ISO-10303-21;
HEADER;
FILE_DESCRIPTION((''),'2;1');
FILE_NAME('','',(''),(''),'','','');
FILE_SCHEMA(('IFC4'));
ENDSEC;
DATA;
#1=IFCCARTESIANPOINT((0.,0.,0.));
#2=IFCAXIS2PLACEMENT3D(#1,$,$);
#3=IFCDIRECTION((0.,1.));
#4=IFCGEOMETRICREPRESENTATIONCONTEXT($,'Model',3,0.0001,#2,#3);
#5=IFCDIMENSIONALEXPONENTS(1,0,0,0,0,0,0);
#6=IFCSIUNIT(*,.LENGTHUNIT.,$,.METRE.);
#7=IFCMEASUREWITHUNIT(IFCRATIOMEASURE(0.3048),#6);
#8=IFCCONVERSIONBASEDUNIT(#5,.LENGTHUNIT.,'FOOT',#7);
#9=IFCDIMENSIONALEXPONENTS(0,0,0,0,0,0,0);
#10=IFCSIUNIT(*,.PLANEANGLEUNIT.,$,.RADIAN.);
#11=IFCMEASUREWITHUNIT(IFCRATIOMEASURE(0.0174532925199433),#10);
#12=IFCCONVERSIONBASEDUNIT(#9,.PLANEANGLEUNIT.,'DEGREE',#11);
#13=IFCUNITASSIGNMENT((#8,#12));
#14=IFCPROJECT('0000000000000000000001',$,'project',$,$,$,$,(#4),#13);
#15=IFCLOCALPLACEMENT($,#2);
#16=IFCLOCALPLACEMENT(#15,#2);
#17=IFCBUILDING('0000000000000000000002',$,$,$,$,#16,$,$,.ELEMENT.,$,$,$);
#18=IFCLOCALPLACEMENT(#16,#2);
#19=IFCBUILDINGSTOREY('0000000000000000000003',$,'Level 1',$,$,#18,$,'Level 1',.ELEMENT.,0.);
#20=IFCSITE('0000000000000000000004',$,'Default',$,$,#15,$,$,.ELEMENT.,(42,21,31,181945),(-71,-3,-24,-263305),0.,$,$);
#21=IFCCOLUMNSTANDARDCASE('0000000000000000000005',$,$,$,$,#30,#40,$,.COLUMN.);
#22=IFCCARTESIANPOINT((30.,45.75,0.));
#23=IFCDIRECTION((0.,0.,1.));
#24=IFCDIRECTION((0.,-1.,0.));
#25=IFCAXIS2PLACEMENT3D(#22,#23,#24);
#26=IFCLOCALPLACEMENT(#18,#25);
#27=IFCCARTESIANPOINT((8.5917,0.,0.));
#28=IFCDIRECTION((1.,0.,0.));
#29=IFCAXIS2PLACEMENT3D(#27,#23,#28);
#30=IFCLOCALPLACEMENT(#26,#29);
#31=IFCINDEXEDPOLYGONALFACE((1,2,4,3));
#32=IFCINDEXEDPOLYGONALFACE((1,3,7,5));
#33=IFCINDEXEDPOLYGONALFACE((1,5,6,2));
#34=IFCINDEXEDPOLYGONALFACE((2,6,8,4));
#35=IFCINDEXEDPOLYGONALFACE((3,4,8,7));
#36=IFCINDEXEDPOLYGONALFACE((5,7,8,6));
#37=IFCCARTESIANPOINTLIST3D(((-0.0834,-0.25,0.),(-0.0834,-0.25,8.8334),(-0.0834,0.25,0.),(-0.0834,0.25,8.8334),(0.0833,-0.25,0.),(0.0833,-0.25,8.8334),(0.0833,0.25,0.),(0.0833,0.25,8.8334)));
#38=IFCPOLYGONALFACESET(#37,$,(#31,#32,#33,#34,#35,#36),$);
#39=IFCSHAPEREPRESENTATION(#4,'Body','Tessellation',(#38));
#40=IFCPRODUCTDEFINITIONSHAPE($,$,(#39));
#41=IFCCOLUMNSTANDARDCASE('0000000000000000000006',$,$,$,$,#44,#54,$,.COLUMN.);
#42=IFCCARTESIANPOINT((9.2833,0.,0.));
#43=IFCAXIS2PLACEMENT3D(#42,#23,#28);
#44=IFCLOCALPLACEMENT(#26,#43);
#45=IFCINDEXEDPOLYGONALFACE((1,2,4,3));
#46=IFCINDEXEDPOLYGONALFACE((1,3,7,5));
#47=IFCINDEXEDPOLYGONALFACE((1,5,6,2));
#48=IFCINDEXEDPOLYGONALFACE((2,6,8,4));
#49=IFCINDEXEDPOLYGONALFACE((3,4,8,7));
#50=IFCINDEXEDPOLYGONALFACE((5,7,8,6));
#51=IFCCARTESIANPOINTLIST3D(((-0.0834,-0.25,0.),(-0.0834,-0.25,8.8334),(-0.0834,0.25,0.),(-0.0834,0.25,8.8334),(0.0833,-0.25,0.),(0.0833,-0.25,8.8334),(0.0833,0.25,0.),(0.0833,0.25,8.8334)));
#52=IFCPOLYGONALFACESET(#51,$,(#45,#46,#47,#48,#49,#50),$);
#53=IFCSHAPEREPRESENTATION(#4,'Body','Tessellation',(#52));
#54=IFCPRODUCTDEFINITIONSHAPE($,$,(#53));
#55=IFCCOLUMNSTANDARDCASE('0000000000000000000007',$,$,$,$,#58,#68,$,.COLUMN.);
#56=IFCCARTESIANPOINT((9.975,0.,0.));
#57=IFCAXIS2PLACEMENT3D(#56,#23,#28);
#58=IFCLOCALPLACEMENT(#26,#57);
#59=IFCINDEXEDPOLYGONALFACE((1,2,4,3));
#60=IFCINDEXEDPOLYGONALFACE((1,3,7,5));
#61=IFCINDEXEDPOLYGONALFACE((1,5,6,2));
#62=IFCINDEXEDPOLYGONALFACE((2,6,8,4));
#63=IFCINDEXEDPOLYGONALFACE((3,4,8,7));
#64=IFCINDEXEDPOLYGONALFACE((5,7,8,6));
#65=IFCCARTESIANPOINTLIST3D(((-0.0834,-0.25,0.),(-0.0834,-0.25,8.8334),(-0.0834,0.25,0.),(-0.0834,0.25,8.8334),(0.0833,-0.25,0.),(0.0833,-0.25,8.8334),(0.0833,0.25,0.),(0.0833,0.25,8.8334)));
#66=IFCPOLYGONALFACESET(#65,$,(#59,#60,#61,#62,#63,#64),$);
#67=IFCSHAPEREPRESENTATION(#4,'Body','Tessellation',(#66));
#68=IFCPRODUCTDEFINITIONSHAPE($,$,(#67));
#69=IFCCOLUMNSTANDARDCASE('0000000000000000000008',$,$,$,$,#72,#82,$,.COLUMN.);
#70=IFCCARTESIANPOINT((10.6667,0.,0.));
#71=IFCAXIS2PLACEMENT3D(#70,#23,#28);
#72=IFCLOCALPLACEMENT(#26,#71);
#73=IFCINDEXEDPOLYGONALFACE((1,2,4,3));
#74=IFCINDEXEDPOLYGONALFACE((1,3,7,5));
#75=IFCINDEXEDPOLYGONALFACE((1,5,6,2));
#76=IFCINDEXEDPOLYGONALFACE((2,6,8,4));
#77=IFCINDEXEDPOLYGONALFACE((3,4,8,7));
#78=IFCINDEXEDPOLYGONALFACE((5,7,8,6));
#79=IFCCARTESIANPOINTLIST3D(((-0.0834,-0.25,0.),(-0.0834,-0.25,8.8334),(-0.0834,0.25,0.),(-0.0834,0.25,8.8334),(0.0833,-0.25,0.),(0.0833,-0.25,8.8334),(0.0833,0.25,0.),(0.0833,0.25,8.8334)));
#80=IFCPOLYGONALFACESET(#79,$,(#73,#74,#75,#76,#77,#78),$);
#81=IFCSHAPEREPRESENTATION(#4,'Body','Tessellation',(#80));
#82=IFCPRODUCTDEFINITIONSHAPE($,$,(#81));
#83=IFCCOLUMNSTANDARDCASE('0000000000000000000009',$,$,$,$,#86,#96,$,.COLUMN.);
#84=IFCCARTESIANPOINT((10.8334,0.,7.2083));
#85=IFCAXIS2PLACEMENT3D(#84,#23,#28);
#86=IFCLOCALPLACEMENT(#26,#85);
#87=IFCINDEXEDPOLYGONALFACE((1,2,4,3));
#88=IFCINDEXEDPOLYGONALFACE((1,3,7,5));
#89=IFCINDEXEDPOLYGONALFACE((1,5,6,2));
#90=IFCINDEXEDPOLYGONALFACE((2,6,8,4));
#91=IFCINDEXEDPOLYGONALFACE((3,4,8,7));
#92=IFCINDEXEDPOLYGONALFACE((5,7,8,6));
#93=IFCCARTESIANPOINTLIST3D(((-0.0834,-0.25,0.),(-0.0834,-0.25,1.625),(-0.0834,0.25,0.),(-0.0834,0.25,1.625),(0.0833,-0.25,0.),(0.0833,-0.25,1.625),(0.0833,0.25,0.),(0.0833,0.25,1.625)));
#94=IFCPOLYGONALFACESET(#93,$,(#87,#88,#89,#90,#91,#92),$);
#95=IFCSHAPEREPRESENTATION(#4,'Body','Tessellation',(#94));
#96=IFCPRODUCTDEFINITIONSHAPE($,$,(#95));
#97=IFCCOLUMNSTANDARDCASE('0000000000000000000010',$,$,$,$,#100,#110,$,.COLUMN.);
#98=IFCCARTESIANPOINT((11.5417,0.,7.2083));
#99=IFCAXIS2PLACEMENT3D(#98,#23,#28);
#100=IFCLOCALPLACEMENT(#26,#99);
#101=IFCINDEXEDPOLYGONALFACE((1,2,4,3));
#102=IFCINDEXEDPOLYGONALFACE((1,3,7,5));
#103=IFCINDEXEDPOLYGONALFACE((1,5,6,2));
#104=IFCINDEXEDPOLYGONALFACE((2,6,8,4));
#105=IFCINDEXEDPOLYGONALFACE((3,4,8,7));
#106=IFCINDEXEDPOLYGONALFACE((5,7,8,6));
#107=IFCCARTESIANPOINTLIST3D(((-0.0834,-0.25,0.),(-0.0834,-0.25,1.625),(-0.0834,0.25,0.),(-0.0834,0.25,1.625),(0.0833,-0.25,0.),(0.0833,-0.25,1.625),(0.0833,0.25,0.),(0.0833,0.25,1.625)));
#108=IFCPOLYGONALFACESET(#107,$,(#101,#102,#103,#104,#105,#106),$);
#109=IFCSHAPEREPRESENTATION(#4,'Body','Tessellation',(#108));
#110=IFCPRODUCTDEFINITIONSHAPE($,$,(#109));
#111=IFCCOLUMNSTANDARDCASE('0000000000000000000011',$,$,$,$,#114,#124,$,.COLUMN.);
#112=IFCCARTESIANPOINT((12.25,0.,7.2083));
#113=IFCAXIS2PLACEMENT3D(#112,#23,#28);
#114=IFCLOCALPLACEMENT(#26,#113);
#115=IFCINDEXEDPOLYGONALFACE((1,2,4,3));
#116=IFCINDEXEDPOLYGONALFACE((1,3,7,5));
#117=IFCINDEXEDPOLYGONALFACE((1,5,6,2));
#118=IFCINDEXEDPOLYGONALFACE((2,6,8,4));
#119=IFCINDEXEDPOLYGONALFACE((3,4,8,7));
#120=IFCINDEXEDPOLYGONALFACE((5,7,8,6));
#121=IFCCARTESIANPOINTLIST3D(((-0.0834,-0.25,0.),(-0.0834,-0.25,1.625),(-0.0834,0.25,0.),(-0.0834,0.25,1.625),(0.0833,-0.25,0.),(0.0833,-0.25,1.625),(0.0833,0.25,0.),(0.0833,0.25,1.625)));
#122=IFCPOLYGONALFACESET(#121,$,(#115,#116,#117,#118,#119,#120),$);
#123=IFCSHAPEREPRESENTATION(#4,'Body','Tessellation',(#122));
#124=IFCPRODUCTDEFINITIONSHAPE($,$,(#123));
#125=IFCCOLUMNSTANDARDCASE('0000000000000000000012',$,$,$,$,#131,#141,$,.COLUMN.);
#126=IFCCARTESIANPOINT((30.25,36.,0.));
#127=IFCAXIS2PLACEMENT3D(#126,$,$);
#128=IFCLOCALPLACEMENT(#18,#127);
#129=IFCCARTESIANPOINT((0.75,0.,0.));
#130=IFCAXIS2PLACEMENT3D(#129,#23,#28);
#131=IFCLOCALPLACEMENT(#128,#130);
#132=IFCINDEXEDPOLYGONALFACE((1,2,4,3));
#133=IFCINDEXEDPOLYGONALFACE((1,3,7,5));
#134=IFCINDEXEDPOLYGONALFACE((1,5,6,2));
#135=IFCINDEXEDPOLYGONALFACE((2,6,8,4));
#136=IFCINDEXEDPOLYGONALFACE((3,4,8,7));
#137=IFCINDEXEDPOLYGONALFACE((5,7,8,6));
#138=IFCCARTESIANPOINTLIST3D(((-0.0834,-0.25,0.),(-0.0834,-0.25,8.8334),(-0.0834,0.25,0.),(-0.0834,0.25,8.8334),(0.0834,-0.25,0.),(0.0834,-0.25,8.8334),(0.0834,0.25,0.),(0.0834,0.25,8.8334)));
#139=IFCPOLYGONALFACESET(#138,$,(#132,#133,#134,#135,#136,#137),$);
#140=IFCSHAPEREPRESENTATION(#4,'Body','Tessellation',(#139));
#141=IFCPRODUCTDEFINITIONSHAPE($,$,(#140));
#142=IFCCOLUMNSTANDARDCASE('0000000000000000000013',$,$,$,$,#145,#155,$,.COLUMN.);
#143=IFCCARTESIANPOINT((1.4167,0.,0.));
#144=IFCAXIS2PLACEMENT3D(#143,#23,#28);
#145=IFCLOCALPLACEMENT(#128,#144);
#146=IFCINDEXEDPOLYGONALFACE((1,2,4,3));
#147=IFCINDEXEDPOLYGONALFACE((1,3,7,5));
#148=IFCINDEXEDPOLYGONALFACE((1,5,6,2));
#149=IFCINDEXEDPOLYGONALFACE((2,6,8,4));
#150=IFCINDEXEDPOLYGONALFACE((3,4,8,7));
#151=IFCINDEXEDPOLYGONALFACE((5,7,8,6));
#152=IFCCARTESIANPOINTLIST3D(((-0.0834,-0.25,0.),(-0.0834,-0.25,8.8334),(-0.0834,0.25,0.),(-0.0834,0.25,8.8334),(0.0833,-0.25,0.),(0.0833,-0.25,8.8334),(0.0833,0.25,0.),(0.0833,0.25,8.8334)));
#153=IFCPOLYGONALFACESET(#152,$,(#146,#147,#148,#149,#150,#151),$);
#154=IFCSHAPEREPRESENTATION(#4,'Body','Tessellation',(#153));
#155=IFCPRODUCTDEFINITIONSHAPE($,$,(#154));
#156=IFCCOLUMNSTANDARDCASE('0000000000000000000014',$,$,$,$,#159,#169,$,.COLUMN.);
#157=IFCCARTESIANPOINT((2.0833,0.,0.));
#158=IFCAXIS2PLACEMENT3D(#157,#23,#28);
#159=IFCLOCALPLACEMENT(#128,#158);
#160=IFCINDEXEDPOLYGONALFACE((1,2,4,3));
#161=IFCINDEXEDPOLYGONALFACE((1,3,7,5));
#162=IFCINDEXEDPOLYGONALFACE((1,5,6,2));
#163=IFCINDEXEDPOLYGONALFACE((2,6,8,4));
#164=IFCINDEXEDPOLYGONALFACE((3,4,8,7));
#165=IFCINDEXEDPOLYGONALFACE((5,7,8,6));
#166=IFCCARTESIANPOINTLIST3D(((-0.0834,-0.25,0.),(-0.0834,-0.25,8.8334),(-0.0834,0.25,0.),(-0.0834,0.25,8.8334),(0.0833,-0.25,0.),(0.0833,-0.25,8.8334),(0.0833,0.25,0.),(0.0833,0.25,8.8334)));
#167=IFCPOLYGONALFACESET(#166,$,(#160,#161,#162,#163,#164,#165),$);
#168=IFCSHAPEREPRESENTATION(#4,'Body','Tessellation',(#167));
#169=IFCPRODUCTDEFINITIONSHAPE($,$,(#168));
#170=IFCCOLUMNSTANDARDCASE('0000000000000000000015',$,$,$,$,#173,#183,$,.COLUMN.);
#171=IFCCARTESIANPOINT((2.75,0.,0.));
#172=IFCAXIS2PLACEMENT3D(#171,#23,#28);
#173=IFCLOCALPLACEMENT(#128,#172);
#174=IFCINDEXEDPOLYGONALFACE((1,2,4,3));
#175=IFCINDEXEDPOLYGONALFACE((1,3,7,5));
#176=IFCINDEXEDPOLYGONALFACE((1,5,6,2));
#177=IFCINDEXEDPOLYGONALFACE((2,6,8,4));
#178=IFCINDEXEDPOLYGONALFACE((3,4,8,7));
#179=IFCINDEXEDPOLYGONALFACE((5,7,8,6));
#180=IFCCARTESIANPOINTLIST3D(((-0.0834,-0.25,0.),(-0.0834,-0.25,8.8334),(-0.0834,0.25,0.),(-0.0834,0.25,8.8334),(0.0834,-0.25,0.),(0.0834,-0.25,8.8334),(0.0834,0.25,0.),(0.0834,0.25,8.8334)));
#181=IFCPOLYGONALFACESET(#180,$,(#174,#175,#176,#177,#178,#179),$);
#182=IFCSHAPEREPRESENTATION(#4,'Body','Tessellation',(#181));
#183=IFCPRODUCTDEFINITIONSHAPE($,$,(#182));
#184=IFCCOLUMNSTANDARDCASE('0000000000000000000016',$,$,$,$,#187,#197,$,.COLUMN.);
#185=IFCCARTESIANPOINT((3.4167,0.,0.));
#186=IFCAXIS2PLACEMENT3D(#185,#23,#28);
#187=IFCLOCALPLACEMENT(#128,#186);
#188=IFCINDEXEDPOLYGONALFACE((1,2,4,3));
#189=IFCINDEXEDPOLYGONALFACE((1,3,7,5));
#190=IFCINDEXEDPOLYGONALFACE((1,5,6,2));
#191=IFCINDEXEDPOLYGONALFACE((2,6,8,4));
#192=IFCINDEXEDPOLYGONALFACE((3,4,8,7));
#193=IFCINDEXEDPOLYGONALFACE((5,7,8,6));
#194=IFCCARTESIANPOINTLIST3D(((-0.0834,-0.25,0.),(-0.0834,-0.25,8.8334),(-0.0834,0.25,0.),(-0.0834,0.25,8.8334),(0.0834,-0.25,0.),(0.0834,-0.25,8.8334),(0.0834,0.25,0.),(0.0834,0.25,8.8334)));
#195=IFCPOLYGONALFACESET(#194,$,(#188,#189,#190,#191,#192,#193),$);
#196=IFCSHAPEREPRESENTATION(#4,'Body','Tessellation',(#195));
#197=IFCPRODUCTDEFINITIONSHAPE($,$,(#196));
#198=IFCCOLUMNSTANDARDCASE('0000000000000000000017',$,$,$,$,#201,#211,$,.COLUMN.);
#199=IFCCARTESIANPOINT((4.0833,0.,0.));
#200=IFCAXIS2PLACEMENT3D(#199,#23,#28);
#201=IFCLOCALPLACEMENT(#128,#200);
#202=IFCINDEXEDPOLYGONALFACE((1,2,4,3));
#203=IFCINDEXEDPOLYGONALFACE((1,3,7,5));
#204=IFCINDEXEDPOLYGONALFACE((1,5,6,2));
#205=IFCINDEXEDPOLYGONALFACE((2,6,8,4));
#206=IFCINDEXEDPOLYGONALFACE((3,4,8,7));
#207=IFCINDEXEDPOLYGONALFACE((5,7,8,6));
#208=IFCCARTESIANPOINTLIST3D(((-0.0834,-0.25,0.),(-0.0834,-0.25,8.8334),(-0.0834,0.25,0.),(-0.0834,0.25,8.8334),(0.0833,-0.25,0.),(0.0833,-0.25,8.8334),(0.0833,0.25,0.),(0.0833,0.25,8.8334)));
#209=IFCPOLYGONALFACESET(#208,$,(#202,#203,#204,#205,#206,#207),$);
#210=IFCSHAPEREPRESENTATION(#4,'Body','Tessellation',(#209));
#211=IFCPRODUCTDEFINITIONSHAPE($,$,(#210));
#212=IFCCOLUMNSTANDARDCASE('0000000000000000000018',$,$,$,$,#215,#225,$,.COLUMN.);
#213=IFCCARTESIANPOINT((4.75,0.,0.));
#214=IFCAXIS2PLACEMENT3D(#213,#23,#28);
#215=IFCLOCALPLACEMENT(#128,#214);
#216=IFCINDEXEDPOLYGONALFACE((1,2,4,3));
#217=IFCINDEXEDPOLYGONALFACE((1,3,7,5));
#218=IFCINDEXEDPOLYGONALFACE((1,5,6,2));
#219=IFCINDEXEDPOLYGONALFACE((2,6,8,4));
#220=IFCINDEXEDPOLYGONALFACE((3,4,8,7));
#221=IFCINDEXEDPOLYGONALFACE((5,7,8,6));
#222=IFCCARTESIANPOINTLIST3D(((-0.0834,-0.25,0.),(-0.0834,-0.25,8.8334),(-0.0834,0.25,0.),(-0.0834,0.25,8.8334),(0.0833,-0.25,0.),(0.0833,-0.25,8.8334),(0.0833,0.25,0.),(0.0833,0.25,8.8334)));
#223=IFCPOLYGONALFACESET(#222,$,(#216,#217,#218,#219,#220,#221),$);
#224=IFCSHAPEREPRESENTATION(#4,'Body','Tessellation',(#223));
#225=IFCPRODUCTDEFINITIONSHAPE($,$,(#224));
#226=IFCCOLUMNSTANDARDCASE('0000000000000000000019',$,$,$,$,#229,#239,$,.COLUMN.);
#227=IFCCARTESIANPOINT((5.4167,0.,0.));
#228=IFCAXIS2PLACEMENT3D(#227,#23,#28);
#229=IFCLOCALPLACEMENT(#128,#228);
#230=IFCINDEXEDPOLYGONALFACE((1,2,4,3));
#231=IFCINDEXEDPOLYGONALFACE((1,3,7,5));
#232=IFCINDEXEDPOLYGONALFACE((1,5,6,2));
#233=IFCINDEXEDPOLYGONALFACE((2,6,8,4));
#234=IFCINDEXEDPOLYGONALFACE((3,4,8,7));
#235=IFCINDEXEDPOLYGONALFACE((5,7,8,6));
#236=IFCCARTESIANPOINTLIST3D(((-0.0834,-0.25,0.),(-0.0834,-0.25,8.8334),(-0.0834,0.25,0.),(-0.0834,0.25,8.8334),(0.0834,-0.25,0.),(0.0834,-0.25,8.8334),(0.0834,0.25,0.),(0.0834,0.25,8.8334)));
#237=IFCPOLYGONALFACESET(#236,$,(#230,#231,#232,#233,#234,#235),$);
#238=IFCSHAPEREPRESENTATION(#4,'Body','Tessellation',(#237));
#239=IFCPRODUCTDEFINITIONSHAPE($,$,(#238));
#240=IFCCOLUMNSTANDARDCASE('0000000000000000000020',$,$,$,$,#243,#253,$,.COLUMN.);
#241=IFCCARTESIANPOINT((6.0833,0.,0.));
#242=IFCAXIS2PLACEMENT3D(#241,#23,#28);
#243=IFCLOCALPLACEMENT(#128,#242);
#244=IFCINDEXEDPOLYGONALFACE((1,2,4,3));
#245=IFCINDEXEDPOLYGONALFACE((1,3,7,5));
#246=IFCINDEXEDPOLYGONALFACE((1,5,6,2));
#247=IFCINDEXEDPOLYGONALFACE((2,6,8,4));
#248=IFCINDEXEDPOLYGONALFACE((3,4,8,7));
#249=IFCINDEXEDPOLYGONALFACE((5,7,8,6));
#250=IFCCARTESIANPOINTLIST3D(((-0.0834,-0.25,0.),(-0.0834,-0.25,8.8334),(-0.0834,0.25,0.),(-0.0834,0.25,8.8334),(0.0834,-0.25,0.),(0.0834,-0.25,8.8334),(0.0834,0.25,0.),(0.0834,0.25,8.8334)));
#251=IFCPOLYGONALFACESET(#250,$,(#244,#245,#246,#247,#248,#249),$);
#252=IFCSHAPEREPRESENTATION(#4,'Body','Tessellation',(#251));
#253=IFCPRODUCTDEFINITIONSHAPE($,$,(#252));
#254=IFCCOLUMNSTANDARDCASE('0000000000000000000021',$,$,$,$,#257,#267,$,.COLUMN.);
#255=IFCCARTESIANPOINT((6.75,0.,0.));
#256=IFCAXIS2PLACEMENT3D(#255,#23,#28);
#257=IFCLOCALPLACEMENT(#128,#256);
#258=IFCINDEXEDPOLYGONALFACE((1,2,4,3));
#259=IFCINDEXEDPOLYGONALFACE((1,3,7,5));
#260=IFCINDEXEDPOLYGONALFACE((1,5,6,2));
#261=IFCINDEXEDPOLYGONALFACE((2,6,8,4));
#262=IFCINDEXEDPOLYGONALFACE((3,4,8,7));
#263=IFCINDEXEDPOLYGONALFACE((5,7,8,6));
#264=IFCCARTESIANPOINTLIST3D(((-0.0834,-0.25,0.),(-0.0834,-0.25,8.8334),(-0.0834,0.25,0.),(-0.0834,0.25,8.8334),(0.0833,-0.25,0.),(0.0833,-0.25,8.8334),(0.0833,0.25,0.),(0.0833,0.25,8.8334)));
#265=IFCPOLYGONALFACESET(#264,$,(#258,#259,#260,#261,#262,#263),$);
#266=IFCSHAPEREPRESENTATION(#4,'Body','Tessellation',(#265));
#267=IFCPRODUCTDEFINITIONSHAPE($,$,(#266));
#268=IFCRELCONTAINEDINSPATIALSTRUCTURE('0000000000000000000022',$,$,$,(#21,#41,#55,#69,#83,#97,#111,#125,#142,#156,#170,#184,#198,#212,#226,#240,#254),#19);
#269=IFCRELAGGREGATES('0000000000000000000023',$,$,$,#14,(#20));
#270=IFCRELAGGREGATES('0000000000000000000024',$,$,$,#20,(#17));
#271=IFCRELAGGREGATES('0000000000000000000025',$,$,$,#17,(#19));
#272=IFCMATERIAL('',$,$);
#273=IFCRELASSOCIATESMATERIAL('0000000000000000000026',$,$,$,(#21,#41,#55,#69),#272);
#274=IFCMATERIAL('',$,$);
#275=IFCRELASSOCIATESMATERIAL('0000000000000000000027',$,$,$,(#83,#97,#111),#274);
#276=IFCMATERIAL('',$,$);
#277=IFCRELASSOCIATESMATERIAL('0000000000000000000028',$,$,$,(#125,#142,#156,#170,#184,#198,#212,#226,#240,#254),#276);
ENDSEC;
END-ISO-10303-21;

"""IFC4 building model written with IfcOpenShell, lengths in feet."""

from ifc_helpers import new_model, entity, si_unit, converted_unit, direction, frame, origin, place, context, project, spatial, rectangle, extrude, material, element, save


model = new_model("IFC4")

# Units and contexts
model_context = context("Model", 3, precision=0.0001, world=origin(), true_north=direction((0.0, 1.0)))
ifc_project = project(units=[converted_unit("LENGTHUNIT", "FOOT", entity("IfcRatioMeasure", 0.3048), si_unit("LENGTHUNIT", "METRE"), dimensions=[1, 0, 0, 0, 0, 0, 0]), converted_unit("PLANEANGLEUNIT", "DEGREE", entity("IfcRatioMeasure", 0.0174532925199433), si_unit("PLANEANGLEUNIT", "RADIAN"), dimensions=[0, 0, 0, 0, 0, 0, 0])], contexts=[model_context])

# Site, building, storey
site_placement = place(None, origin())
site = spatial("IfcSite", under=ifc_project, at=site_placement, Name="Default", CompositionType="ELEMENT", RefLatitude=(42, 21, 31, 181945), RefLongitude=(-71, -3, -24, -263305), RefElevation=0.0)
building_placement = place(site_placement, origin())
building = spatial("IfcBuilding", under=site, at=building_placement, CompositionType="ELEMENT")
storey_placement = place(building_placement, origin())
storey = spatial("IfcBuildingStorey", under=building, at=storey_placement, Name="Level 1", LongName="Level 1", CompositionType="ELEMENT", Elevation=0.0)

# Columns
ifc_material_1 = material(Name="")
placement_1 = place(storey_placement, frame((30.0, 45.75, 0.0), z_axis=(0.0, 0.0, 1.0), x_axis=(0.0, -1.0, 0.0)))
for number, where, z_axis, x_axis in (
    (1, (8.5917, 0.0, 0.0), (0.0, 0.0, 1.0), (1.0, 0.0, 0.0)),
    (2, (9.2833, 0.0, 0.0), (0.0, 0.0, 1.0), (1.0, 0.0, 0.0)),
    (3, (9.975, 0.0, 0.0), (0.0, 0.0, 1.0), (1.0, 0.0, 0.0)),
    (4, (10.6667, 0.0, 0.0), (0.0, 0.0, 1.0), (1.0, 0.0, 0.0)),
):
    element("IfcColumnStandardCase", number, at=place(placement_1, frame(where, z_axis=z_axis, x_axis=x_axis)), inside=storey, material=ifc_material_1, PredefinedType="COLUMN", context=model_context, shape_type="SweptSolid", body=[
        extrude(rectangle(XDim=0.1667, YDim=0.5), origin(), (0.0, 0.0, 1.0), 8.8334),
    ])
ifc_material_2 = material(Name="")
for number, where, z_axis, x_axis in (
    (5, (10.8334, 0.0, 7.2083), (0.0, 0.0, 1.0), (1.0, 0.0, 0.0)),
    (6, (11.5417, 0.0, 7.2083), (0.0, 0.0, 1.0), (1.0, 0.0, 0.0)),
    (7, (12.25, 0.0, 7.2083), (0.0, 0.0, 1.0), (1.0, 0.0, 0.0)),
):
    element("IfcColumnStandardCase", number, at=place(placement_1, frame(where, z_axis=z_axis, x_axis=x_axis)), inside=storey, material=ifc_material_2, PredefinedType="COLUMN", context=model_context, shape_type="SweptSolid", body=[
        extrude(rectangle(XDim=0.1667, YDim=0.5), origin(), (0.0, 0.0, 1.0), 1.625),
    ])
ifc_material_3 = material(Name="")
placement_2 = place(storey_placement, frame((30.25, 36.0, 0.0)))
for number, where, z_axis, x_axis in (
    (8, (0.75, 0.0, 0.0), (0.0, 0.0, 1.0), (1.0, 0.0, 0.0)),
    (9, (1.4167, 0.0, 0.0), (0.0, 0.0, 1.0), (1.0, 0.0, 0.0)),
    (10, (2.0833, 0.0, 0.0), (0.0, 0.0, 1.0), (1.0, 0.0, 0.0)),
    (11, (2.75, 0.0, 0.0), (0.0, 0.0, 1.0), (1.0, 0.0, 0.0)),
    (12, (3.4167, 0.0, 0.0), (0.0, 0.0, 1.0), (1.0, 0.0, 0.0)),
    (13, (4.0833, 0.0, 0.0), (0.0, 0.0, 1.0), (1.0, 0.0, 0.0)),
    (14, (4.75, 0.0, 0.0), (0.0, 0.0, 1.0), (1.0, 0.0, 0.0)),
    (15, (5.4167, 0.0, 0.0), (0.0, 0.0, 1.0), (1.0, 0.0, 0.0)),
    (16, (6.0833, 0.0, 0.0), (0.0, 0.0, 1.0), (1.0, 0.0, 0.0)),
    (17, (6.75, 0.0, 0.0), (0.0, 0.0, 1.0), (1.0, 0.0, 0.0)),
):
    element("IfcColumnStandardCase", number, at=place(placement_2, frame(where, z_axis=z_axis, x_axis=x_axis)), inside=storey, material=ifc_material_3, PredefinedType="COLUMN", context=model_context, shape_type="SweptSolid", body=[
        extrude(rectangle(XDim=0.1667, YDim=0.5), origin(), (0.0, 0.0, 1.0), 8.8334),
    ])

save(model, "model.ifc")
